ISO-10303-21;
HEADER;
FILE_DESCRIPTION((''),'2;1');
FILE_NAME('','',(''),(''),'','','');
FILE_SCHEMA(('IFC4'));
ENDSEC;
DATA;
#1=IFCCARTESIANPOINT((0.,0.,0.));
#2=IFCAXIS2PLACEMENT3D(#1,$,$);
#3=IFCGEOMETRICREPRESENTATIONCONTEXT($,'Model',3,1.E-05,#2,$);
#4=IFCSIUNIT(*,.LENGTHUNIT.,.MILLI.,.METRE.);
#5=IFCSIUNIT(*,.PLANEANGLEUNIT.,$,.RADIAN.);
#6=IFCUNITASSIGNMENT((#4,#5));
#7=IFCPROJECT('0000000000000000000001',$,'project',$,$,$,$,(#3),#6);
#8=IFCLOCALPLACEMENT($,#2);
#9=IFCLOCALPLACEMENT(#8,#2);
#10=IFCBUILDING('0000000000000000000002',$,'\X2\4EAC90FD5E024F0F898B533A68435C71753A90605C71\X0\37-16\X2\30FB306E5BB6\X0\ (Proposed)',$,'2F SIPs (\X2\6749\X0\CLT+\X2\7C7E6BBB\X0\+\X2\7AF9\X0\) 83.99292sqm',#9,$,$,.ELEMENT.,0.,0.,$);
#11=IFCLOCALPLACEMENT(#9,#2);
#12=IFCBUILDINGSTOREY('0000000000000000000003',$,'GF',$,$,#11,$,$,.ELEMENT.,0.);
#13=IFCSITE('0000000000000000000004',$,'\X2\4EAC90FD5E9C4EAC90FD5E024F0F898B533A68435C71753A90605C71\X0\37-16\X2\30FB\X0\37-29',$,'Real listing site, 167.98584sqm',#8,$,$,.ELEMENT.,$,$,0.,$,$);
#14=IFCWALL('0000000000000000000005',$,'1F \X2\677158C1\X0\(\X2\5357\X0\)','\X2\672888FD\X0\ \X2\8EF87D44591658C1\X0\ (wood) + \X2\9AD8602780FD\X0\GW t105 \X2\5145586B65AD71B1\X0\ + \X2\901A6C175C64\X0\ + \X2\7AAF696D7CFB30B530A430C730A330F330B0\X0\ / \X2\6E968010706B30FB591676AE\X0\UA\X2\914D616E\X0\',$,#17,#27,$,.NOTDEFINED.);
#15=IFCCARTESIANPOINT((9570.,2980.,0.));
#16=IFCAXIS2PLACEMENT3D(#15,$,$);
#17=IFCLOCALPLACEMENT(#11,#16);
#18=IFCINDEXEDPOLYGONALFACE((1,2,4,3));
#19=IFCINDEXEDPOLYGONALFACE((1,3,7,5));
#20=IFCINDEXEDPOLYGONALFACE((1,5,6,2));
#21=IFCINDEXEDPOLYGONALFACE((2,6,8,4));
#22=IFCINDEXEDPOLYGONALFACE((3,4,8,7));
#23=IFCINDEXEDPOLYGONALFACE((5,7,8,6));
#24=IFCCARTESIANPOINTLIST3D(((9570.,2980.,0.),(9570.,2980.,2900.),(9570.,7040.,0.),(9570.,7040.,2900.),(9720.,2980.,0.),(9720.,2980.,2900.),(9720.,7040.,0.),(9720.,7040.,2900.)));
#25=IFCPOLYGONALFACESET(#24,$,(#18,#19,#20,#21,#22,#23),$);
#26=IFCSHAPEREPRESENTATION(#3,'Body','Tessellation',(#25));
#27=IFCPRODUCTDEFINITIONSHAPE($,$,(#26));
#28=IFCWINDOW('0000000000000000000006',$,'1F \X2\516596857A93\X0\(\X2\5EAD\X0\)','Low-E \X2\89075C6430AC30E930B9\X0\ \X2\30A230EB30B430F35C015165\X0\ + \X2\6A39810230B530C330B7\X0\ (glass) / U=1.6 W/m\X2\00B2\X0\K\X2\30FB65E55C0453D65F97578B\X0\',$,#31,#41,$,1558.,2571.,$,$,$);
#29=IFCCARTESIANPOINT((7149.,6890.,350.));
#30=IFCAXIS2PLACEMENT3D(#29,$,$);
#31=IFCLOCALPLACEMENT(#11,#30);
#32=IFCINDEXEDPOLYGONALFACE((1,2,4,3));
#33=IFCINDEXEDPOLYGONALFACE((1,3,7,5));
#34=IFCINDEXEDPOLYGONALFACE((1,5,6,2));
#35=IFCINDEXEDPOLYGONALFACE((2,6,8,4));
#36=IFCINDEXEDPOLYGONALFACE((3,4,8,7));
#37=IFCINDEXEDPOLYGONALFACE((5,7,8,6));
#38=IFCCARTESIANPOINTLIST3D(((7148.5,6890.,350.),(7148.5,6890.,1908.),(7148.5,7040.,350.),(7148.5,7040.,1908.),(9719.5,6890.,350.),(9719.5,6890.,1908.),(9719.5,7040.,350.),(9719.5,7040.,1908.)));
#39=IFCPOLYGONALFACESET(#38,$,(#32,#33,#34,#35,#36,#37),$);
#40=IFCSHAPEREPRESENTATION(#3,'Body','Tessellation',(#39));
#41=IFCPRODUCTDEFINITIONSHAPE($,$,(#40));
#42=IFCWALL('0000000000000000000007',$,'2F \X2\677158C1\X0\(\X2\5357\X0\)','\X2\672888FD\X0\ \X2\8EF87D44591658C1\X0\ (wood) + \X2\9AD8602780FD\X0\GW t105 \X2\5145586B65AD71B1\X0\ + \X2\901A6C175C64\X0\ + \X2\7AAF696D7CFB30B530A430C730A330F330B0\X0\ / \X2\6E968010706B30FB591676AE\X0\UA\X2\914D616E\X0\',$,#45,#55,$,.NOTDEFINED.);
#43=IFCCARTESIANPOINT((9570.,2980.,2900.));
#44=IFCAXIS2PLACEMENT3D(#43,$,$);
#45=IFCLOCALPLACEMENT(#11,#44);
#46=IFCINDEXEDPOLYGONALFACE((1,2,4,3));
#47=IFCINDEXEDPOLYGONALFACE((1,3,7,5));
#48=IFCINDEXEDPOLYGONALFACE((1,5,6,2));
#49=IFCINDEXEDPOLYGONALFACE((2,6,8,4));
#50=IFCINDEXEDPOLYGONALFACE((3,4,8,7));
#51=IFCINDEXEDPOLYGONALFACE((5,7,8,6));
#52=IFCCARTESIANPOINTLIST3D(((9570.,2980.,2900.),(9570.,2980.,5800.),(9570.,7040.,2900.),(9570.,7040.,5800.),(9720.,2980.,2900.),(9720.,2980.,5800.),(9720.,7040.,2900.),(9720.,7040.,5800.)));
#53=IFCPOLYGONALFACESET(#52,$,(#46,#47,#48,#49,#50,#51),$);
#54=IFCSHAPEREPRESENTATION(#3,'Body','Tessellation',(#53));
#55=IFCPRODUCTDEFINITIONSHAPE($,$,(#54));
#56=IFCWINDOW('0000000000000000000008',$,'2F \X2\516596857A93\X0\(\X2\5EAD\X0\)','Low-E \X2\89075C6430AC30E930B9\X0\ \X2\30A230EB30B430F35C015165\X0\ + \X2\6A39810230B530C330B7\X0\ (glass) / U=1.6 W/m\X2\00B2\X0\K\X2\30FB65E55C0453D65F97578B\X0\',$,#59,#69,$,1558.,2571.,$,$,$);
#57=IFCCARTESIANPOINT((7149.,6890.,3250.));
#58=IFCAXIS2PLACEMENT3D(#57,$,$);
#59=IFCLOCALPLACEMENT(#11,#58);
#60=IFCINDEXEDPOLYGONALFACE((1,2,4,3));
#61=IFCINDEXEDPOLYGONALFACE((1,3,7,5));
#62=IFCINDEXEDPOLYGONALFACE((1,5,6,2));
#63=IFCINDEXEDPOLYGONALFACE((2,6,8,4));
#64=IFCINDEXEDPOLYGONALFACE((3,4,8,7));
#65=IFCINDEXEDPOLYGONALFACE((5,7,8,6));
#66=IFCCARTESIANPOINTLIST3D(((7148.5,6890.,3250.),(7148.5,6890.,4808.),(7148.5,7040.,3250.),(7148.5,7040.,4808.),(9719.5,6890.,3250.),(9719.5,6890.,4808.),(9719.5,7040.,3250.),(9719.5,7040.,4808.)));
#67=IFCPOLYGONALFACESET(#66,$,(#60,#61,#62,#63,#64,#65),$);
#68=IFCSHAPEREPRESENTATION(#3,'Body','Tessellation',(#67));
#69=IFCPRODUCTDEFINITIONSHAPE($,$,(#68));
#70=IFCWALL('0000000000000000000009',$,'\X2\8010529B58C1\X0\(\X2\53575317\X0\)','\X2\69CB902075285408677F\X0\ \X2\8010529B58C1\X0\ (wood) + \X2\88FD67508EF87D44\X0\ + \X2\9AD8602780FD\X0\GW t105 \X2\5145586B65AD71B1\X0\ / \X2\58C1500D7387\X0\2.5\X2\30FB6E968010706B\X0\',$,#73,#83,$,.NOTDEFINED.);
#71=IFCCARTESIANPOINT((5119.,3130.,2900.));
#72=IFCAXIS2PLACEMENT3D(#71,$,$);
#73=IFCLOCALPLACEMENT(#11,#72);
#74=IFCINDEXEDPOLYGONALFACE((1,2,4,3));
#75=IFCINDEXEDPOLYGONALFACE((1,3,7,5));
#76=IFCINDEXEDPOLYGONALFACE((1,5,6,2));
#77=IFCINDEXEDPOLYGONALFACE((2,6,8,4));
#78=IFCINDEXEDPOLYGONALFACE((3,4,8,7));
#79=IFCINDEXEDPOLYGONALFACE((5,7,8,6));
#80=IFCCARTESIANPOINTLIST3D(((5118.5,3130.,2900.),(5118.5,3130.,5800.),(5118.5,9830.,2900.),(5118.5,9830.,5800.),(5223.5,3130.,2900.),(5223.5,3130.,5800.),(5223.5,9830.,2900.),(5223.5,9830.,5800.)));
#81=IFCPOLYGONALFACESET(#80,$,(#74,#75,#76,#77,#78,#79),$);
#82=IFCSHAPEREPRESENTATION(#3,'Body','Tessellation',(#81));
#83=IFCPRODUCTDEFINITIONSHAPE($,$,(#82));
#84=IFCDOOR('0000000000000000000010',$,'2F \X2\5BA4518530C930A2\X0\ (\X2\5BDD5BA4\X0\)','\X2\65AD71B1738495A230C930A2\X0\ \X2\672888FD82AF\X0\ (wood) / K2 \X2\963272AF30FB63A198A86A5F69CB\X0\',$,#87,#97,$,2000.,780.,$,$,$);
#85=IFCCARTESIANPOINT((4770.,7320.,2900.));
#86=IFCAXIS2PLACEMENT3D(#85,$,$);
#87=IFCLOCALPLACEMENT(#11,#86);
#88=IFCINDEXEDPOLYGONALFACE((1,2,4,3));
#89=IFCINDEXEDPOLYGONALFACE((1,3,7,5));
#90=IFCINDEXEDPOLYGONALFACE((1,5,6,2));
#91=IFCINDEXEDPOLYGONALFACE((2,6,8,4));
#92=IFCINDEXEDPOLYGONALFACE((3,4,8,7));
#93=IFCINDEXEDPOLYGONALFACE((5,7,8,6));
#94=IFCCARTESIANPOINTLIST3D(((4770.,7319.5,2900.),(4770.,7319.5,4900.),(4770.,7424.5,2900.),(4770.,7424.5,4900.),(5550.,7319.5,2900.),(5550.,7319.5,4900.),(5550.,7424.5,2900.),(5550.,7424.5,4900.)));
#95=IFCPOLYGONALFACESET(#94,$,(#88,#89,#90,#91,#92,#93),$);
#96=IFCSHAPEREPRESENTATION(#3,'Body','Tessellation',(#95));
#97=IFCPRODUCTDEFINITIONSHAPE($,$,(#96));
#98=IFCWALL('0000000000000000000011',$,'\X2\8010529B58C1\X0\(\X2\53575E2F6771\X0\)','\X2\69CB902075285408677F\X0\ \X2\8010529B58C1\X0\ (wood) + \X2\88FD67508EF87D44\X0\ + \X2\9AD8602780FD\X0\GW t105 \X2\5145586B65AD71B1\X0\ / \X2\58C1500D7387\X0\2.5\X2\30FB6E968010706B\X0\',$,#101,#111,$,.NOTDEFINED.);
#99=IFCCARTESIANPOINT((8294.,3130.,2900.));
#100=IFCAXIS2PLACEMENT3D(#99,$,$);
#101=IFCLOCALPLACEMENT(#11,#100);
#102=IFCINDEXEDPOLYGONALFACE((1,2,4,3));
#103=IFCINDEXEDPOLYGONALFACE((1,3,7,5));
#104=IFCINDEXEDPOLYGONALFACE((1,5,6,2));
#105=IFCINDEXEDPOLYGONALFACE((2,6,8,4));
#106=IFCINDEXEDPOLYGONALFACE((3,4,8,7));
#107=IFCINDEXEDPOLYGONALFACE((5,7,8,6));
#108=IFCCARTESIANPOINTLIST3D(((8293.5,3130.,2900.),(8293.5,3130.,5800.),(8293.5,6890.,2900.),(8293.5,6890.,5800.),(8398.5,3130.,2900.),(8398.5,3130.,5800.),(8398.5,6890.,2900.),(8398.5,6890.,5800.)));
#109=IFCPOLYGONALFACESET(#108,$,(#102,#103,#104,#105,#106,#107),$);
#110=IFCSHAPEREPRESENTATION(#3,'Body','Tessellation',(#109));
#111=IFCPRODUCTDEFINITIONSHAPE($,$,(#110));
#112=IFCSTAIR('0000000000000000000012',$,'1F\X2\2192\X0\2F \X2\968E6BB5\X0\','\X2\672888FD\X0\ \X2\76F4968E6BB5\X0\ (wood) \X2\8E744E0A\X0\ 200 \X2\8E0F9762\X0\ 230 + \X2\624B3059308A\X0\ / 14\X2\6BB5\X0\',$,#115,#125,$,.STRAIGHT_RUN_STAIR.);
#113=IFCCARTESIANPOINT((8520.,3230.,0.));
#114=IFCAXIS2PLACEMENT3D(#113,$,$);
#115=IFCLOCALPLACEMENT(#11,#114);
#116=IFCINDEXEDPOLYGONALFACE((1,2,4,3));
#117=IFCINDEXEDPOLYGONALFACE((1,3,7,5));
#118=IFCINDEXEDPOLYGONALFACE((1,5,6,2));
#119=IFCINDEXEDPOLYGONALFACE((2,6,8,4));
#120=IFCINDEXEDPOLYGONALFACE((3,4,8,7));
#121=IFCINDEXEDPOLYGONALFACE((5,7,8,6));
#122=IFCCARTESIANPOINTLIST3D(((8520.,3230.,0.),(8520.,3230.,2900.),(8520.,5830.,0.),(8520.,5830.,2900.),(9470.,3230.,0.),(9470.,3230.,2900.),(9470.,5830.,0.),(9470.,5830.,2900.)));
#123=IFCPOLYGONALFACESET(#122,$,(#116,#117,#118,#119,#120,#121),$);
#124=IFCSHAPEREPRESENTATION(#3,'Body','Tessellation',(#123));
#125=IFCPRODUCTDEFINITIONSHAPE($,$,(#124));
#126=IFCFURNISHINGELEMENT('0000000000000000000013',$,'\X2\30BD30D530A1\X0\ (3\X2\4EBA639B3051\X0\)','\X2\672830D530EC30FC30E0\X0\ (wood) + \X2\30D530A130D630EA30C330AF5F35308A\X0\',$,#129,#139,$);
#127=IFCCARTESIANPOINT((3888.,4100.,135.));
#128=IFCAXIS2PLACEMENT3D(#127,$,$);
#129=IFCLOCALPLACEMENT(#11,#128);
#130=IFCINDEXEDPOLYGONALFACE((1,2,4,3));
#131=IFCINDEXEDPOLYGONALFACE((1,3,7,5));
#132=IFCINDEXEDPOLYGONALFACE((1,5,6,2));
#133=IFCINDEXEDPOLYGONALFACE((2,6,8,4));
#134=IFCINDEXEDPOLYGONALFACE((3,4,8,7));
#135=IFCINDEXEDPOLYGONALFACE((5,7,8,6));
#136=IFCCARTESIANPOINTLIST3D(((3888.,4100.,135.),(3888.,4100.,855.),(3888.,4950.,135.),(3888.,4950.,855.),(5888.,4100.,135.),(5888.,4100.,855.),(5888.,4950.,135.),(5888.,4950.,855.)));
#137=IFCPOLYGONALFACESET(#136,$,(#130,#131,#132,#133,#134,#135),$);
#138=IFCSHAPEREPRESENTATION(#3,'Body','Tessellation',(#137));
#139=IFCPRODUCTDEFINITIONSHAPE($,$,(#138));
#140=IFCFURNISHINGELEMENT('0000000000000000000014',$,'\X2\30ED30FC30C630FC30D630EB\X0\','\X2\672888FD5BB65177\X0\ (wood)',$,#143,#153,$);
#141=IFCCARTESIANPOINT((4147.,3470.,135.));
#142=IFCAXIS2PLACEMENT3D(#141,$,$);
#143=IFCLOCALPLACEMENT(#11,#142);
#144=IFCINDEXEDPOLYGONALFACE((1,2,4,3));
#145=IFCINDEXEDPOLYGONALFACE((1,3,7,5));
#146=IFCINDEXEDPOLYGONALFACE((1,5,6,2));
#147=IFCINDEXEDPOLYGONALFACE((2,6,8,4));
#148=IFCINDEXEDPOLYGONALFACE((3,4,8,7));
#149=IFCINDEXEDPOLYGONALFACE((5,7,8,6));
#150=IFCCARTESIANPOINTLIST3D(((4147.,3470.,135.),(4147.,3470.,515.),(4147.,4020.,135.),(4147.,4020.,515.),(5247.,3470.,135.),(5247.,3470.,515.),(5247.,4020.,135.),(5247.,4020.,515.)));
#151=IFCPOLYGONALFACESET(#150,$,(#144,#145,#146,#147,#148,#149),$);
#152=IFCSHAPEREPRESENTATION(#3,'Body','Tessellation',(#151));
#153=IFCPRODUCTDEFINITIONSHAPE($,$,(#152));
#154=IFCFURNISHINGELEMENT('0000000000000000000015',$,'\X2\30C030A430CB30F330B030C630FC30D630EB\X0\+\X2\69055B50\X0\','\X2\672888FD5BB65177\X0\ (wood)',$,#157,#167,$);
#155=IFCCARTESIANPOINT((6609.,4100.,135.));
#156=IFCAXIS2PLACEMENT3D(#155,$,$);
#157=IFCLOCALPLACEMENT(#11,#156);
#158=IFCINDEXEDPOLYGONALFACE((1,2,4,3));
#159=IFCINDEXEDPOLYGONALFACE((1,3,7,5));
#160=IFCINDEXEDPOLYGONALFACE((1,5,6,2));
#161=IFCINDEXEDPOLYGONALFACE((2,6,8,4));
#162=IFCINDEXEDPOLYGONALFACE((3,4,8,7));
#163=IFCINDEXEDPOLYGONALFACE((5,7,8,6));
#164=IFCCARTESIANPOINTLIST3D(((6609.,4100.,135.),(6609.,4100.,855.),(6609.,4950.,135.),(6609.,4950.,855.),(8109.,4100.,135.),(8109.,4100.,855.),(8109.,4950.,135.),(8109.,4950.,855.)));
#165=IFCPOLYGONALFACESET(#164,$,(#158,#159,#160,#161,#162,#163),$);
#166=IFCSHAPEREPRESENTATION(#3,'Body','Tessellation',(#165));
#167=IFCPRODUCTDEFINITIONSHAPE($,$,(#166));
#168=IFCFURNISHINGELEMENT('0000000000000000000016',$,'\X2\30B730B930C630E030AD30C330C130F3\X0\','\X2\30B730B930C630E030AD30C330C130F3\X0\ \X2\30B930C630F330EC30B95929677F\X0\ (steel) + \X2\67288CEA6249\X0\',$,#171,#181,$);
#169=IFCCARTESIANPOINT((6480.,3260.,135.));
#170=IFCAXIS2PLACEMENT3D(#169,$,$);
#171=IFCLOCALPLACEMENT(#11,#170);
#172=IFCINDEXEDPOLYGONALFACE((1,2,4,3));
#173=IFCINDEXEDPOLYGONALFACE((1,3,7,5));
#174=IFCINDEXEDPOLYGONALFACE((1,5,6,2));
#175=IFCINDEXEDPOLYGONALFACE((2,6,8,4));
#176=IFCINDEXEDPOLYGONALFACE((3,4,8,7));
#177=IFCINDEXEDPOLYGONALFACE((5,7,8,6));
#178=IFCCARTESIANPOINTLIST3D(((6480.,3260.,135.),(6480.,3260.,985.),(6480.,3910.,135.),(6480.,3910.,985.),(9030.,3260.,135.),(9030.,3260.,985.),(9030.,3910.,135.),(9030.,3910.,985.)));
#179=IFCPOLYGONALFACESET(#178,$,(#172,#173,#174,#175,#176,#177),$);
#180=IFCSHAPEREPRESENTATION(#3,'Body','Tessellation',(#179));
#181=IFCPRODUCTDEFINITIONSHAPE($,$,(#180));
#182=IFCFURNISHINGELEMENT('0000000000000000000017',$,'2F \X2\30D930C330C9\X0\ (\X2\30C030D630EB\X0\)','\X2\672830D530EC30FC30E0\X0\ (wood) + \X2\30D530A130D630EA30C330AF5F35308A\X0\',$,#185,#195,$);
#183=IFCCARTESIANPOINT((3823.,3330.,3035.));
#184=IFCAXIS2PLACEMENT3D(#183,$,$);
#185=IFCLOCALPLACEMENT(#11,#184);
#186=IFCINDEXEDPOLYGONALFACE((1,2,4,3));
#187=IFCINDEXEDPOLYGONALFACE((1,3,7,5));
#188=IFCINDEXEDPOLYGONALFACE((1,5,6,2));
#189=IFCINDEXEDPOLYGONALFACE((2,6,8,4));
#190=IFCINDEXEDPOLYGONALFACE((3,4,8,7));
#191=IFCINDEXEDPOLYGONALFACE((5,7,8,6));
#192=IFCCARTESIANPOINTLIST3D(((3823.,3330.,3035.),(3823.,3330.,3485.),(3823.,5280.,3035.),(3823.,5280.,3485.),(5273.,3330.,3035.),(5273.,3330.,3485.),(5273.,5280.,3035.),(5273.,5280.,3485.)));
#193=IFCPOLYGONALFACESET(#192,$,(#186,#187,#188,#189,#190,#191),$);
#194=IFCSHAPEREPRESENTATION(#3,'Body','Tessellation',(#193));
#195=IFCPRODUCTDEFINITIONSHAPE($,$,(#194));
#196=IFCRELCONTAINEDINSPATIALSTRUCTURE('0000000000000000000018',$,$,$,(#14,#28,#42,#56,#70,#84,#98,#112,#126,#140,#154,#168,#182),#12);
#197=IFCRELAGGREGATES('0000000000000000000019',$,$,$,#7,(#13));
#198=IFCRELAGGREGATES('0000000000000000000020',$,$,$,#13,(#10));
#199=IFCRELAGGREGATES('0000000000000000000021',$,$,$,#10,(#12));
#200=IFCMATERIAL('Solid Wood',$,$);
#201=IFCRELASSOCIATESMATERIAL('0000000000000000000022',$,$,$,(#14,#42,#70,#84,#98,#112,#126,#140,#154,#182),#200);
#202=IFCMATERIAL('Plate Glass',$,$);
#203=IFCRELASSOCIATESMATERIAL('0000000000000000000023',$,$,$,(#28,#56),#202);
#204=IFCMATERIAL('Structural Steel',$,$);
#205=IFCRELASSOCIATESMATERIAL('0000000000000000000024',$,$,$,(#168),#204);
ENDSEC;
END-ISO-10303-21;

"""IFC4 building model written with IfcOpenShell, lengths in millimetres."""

from ifc_helpers import new_model, si_unit, frame, frame_2d, origin, place, context, project, spatial, rectangle, extrude, material, element, fill, save


model = new_model("IFC4")

# Units and contexts
model_context = context("Model", 3, precision=1e-05, world=origin())
ifc_project = project(units=[si_unit("LENGTHUNIT", "METRE", prefix="MILLI"), si_unit("PLANEANGLEUNIT", "RADIAN")], contexts=[model_context])

# Site, building, storey
site_placement = place(None, origin())
site = spatial("IfcSite", under=ifc_project, at=site_placement, Name="京都府京都市伏見区桃山町遠山37-16・37-29", ObjectType="Real listing site, 167.98584sqm", CompositionType="ELEMENT", RefElevation=0.0)
building_placement = place(site_placement, origin())
building = spatial("IfcBuilding", under=site, at=building_placement, Name="京都市伏見区桃山町遠山37-16・の家 (Proposed)", ObjectType="2F SIPs (杉CLT+籾殻+竹) 83.99292sqm", CompositionType="ELEMENT", ElevationOfRefHeight=0.0, ElevationOfTerrain=0.0)
storey_placement = place(building_placement, origin())
storey = spatial("IfcBuildingStorey", under=building, at=storey_placement, Name="GF", CompositionType="ELEMENT", Elevation=0.0)

# Wall, opening, window
ifc_material_1 = material(Name="Solid Wood")
wall_1_placement = place(storey_placement, frame((9570.0, 2980.0, 0.0)))
wall_1 = element("IfcWall", 1, at=wall_1_placement, inside=storey, material=ifc_material_1, Name="1F 東壁(南)", Description="木製 軸組外壁 (wood) + 高性能GW t105 充填断熱 + 通気層 + 窯業系サイディング / 準耐火・外皮UA配慮", PredefinedType="NOTDEFINED", context=model_context, shape_type="SweptSolid", body=[
    extrude(rectangle(XDim=150.0, YDim=4060.0, at=frame_2d((75.0, 2030.0))), frame((9570.0, 2980.0, 0.0)), (0.0, 0.0, 1.0), 2900.0),
])
opening_1_placement = place(storey_placement, frame((7149.0, 6890.0, 350.0)))
opening_1 = element("IfcOpeningElement", 2, at=opening_1_placement, cuts=wall_1, PredefinedType="NOTDEFINED", context=model_context, shape_type="SweptSolid", body=[
    extrude(rectangle(XDim=2571.0, YDim=150.0, at=frame_2d((1285.0, 75.0))), frame((7149.0, 6890.0, 350.0)), (0.0, 0.0, 1.0), 1558.0),
])
ifc_material_2 = material(Name="Plate Glass")
window_1_placement = place(storey_placement, frame((7149.0, 6890.0, 350.0)))
window_1 = element("IfcWindow", 3, at=window_1_placement, inside=storey, material=ifc_material_2, Name="1F 入隅窓(庭)", Description="Low-E 複層ガラス アルゴン封入 + 樹脂サッシ (glass) / U=1.6 W/m²K・日射取得型", OverallHeight=1558.0, OverallWidth=2571.0, context=model_context, shape_type="SweptSolid", body=[
    extrude(rectangle(XDim=2571.0, YDim=150.0, at=frame_2d((1285.0, 75.0))), frame((7149.0, 6890.0, 350.0)), (0.0, 0.0, 1.0), 1558.0),
])
fill(opening_1, window_1)

# Wall, opening, window
wall_2_placement = place(storey_placement, frame((9570.0, 2980.0, 2900.0)))
wall_2 = element("IfcWall", 4, at=wall_2_placement, inside=storey, material=ifc_material_1, Name="2F 東壁(南)", Description="木製 軸組外壁 (wood) + 高性能GW t105 充填断熱 + 通気層 + 窯業系サイディング / 準耐火・外皮UA配慮", PredefinedType="NOTDEFINED", context=model_context, shape_type="SweptSolid", body=[
    extrude(rectangle(XDim=150.0, YDim=4060.0, at=frame_2d((75.0, 2030.0))), frame((9570.0, 2980.0, 2900.0)), (0.0, 0.0, 1.0), 2900.0),
])
opening_2_placement = place(storey_placement, frame((7149.0, 6890.0, 3250.0)))
opening_2 = element("IfcOpeningElement", 5, at=opening_2_placement, cuts=wall_2, PredefinedType="NOTDEFINED", context=model_context, shape_type="SweptSolid", body=[
    extrude(rectangle(XDim=2571.0, YDim=150.0, at=frame_2d((1285.0, 75.0))), frame((7149.0, 6890.0, 3250.0)), (0.0, 0.0, 1.0), 1558.0),
])
window_2_placement = place(storey_placement, frame((7149.0, 6890.0, 3250.0)))
window_2 = element("IfcWindow", 6, at=window_2_placement, inside=storey, material=ifc_material_2, Name="2F 入隅窓(庭)", Description="Low-E 複層ガラス アルゴン封入 + 樹脂サッシ (glass) / U=1.6 W/m²K・日射取得型", OverallHeight=1558.0, OverallWidth=2571.0, context=model_context, shape_type="SweptSolid", body=[
    extrude(rectangle(XDim=2571.0, YDim=150.0, at=frame_2d((1285.0, 75.0))), frame((7149.0, 6890.0, 3250.0)), (0.0, 0.0, 1.0), 1558.0),
])
fill(opening_2, window_2)

# Wall, opening, door
wall_3_placement = place(storey_placement, frame((5119.0, 3130.0, 2900.0)))
wall_3 = element("IfcWall", 7, at=wall_3_placement, inside=storey, material=ifc_material_1, Name="耐力壁(南北)", Description="構造用合板 耐力壁 (wood) + 製材軸組 + 高性能GW t105 充填断熱 / 壁倍率2.5・準耐火", PredefinedType="NOTDEFINED", context=model_context, shape_type="SweptSolid", body=[
    extrude(rectangle(XDim=105.0, YDim=6700.0, at=frame_2d((52.0, 3350.0))), frame((5119.0, 3130.0, 2900.0)), (0.0, 0.0, 1.0), 2900.0),
])
opening_3_placement = place(storey_placement, frame((4770.0, 7320.0, 2900.0)))
opening_3 = element("IfcOpeningElement", 8, at=opening_3_placement, cuts=wall_3, PredefinedType="NOTDEFINED", context=model_context, shape_type="SweptSolid", body=[
    extrude(rectangle(XDim=780.0, YDim=105.0, at=frame_2d((390.0, 52.0))), frame((4770.0, 7320.0, 2900.0)), (0.0, 0.0, 1.0), 2000.0),
])
door_1_placement = place(storey_placement, frame((4770.0, 7320.0, 2900.0)))
door_1 = element("IfcDoor", 9, at=door_1_placement, inside=storey, material=ifc_material_1, Name="2F 室内ドア (寝室)", Description="断熱玄関ドア 木製芯 (wood) / K2 防犯・採風機構", OverallHeight=2000.0, OverallWidth=780.0, context=model_context, shape_type="SweptSolid", body=[
    extrude(rectangle(XDim=780.0, YDim=105.0, at=frame_2d((390.0, 52.0))), frame((4770.0, 7320.0, 2900.0)), (0.0, 0.0, 1.0), 2000.0),
])
fill(opening_3, door_1)

# Wall
wall_4_placement = place(storey_placement, frame((8294.0, 3130.0, 2900.0)))
element("IfcWall", 10, at=wall_4_placement, inside=storey, material=ifc_material_1, Name="耐力壁(南帯東)", Description="構造用合板 耐力壁 (wood) + 製材軸組 + 高性能GW t105 充填断熱 / 壁倍率2.5・準耐火", PredefinedType="NOTDEFINED", context=model_context, shape_type="SweptSolid", body=[
    extrude(rectangle(XDim=105.0, YDim=3760.0, at=frame_2d((52.0, 1880.0))), frame((8294.0, 3130.0, 2900.0)), (0.0, 0.0, 1.0), 2900.0),
])

# Stair
stair_placement = place(storey_placement, frame((8520.0, 3230.0, 0.0)))
element("IfcStair", 11, at=stair_placement, inside=storey, material=ifc_material_1, Name="1F→2F 階段", Description="木製 直階段 (wood) 蹴上 200 踏面 230 + 手すり / 14段", PredefinedType="STRAIGHT_RUN_STAIR", context=model_context, shape_type="SweptSolid", body=[
    extrude(rectangle(XDim=950.0, YDim=2600.0, at=frame_2d((475.0, 1300.0))), frame((8520.0, 3230.0, 0.0)), (0.0, 0.0, 1.0), 2900.0),
])

# Furnishing elements
furnishing_1_placement = place(storey_placement, frame((3888.0, 4100.0, 135.0)))
element("IfcFurnishingElement", 12, at=furnishing_1_placement, inside=storey, material=ifc_material_1, Name="ソファ (3人掛け)", Description="木フレーム (wood) + ファブリック張り", context=model_context, shape_type="SweptSolid", body=[
    extrude(rectangle(XDim=2000.0, YDim=850.0, at=frame_2d((1000.0, 425.0))), frame((3888.0, 4100.0, 135.0)), (0.0, 0.0, 1.0), 720.0),
])
furnishing_2_placement = place(storey_placement, frame((4147.0, 3470.0, 135.0)))
element("IfcFurnishingElement", 13, at=furnishing_2_placement, inside=storey, material=ifc_material_1, Name="ローテーブル", Description="木製家具 (wood)", context=model_context, shape_type="SweptSolid", body=[
    extrude(rectangle(XDim=1100.0, YDim=550.0, at=frame_2d((550.0, 275.0))), frame((4147.0, 3470.0, 135.0)), (0.0, 0.0, 1.0), 380.0),
])
furnishing_3_placement = place(storey_placement, frame((6609.0, 4100.0, 135.0)))
element("IfcFurnishingElement", 14, at=furnishing_3_placement, inside=storey, material=ifc_material_1, Name="ダイニングテーブル+椅子", Description="木製家具 (wood)", context=model_context, shape_type="SweptSolid", body=[
    extrude(rectangle(XDim=1500.0, YDim=850.0, at=frame_2d((750.0, 425.0))), frame((6609.0, 4100.0, 135.0)), (0.0, 0.0, 1.0), 720.0),
])
ifc_material_3 = material(Name="Structural Steel")
furnishing_4_placement = place(storey_placement, frame((6480.0, 3260.0, 135.0)))
element("IfcFurnishingElement", 15, at=furnishing_4_placement, inside=storey, material=ifc_material_3, Name="システムキッチン", Description="システムキッチン ステンレス天板 (steel) + 木質扉", context=model_context, shape_type="SweptSolid", body=[
    extrude(rectangle(XDim=2550.0, YDim=650.0, at=frame_2d((1275.0, 325.0))), frame((6480.0, 3260.0, 135.0)), (0.0, 0.0, 1.0), 850.0),
])
furnishing_5_placement = place(storey_placement, frame((3823.0, 3330.0, 3035.0)))
element("IfcFurnishingElement", 16, at=furnishing_5_placement, inside=storey, material=ifc_material_1, Name="2F ベッド (ダブル)", Description="木フレーム (wood) + ファブリック張り", context=model_context, shape_type="SweptSolid", body=[
    extrude(rectangle(XDim=1450.0, YDim=1950.0, at=frame_2d((725.0, 975.0))), frame((3823.0, 3330.0, 3035.0)), (0.0, 0.0, 1.0), 450.0),
])

save(model, "model.ifc")
